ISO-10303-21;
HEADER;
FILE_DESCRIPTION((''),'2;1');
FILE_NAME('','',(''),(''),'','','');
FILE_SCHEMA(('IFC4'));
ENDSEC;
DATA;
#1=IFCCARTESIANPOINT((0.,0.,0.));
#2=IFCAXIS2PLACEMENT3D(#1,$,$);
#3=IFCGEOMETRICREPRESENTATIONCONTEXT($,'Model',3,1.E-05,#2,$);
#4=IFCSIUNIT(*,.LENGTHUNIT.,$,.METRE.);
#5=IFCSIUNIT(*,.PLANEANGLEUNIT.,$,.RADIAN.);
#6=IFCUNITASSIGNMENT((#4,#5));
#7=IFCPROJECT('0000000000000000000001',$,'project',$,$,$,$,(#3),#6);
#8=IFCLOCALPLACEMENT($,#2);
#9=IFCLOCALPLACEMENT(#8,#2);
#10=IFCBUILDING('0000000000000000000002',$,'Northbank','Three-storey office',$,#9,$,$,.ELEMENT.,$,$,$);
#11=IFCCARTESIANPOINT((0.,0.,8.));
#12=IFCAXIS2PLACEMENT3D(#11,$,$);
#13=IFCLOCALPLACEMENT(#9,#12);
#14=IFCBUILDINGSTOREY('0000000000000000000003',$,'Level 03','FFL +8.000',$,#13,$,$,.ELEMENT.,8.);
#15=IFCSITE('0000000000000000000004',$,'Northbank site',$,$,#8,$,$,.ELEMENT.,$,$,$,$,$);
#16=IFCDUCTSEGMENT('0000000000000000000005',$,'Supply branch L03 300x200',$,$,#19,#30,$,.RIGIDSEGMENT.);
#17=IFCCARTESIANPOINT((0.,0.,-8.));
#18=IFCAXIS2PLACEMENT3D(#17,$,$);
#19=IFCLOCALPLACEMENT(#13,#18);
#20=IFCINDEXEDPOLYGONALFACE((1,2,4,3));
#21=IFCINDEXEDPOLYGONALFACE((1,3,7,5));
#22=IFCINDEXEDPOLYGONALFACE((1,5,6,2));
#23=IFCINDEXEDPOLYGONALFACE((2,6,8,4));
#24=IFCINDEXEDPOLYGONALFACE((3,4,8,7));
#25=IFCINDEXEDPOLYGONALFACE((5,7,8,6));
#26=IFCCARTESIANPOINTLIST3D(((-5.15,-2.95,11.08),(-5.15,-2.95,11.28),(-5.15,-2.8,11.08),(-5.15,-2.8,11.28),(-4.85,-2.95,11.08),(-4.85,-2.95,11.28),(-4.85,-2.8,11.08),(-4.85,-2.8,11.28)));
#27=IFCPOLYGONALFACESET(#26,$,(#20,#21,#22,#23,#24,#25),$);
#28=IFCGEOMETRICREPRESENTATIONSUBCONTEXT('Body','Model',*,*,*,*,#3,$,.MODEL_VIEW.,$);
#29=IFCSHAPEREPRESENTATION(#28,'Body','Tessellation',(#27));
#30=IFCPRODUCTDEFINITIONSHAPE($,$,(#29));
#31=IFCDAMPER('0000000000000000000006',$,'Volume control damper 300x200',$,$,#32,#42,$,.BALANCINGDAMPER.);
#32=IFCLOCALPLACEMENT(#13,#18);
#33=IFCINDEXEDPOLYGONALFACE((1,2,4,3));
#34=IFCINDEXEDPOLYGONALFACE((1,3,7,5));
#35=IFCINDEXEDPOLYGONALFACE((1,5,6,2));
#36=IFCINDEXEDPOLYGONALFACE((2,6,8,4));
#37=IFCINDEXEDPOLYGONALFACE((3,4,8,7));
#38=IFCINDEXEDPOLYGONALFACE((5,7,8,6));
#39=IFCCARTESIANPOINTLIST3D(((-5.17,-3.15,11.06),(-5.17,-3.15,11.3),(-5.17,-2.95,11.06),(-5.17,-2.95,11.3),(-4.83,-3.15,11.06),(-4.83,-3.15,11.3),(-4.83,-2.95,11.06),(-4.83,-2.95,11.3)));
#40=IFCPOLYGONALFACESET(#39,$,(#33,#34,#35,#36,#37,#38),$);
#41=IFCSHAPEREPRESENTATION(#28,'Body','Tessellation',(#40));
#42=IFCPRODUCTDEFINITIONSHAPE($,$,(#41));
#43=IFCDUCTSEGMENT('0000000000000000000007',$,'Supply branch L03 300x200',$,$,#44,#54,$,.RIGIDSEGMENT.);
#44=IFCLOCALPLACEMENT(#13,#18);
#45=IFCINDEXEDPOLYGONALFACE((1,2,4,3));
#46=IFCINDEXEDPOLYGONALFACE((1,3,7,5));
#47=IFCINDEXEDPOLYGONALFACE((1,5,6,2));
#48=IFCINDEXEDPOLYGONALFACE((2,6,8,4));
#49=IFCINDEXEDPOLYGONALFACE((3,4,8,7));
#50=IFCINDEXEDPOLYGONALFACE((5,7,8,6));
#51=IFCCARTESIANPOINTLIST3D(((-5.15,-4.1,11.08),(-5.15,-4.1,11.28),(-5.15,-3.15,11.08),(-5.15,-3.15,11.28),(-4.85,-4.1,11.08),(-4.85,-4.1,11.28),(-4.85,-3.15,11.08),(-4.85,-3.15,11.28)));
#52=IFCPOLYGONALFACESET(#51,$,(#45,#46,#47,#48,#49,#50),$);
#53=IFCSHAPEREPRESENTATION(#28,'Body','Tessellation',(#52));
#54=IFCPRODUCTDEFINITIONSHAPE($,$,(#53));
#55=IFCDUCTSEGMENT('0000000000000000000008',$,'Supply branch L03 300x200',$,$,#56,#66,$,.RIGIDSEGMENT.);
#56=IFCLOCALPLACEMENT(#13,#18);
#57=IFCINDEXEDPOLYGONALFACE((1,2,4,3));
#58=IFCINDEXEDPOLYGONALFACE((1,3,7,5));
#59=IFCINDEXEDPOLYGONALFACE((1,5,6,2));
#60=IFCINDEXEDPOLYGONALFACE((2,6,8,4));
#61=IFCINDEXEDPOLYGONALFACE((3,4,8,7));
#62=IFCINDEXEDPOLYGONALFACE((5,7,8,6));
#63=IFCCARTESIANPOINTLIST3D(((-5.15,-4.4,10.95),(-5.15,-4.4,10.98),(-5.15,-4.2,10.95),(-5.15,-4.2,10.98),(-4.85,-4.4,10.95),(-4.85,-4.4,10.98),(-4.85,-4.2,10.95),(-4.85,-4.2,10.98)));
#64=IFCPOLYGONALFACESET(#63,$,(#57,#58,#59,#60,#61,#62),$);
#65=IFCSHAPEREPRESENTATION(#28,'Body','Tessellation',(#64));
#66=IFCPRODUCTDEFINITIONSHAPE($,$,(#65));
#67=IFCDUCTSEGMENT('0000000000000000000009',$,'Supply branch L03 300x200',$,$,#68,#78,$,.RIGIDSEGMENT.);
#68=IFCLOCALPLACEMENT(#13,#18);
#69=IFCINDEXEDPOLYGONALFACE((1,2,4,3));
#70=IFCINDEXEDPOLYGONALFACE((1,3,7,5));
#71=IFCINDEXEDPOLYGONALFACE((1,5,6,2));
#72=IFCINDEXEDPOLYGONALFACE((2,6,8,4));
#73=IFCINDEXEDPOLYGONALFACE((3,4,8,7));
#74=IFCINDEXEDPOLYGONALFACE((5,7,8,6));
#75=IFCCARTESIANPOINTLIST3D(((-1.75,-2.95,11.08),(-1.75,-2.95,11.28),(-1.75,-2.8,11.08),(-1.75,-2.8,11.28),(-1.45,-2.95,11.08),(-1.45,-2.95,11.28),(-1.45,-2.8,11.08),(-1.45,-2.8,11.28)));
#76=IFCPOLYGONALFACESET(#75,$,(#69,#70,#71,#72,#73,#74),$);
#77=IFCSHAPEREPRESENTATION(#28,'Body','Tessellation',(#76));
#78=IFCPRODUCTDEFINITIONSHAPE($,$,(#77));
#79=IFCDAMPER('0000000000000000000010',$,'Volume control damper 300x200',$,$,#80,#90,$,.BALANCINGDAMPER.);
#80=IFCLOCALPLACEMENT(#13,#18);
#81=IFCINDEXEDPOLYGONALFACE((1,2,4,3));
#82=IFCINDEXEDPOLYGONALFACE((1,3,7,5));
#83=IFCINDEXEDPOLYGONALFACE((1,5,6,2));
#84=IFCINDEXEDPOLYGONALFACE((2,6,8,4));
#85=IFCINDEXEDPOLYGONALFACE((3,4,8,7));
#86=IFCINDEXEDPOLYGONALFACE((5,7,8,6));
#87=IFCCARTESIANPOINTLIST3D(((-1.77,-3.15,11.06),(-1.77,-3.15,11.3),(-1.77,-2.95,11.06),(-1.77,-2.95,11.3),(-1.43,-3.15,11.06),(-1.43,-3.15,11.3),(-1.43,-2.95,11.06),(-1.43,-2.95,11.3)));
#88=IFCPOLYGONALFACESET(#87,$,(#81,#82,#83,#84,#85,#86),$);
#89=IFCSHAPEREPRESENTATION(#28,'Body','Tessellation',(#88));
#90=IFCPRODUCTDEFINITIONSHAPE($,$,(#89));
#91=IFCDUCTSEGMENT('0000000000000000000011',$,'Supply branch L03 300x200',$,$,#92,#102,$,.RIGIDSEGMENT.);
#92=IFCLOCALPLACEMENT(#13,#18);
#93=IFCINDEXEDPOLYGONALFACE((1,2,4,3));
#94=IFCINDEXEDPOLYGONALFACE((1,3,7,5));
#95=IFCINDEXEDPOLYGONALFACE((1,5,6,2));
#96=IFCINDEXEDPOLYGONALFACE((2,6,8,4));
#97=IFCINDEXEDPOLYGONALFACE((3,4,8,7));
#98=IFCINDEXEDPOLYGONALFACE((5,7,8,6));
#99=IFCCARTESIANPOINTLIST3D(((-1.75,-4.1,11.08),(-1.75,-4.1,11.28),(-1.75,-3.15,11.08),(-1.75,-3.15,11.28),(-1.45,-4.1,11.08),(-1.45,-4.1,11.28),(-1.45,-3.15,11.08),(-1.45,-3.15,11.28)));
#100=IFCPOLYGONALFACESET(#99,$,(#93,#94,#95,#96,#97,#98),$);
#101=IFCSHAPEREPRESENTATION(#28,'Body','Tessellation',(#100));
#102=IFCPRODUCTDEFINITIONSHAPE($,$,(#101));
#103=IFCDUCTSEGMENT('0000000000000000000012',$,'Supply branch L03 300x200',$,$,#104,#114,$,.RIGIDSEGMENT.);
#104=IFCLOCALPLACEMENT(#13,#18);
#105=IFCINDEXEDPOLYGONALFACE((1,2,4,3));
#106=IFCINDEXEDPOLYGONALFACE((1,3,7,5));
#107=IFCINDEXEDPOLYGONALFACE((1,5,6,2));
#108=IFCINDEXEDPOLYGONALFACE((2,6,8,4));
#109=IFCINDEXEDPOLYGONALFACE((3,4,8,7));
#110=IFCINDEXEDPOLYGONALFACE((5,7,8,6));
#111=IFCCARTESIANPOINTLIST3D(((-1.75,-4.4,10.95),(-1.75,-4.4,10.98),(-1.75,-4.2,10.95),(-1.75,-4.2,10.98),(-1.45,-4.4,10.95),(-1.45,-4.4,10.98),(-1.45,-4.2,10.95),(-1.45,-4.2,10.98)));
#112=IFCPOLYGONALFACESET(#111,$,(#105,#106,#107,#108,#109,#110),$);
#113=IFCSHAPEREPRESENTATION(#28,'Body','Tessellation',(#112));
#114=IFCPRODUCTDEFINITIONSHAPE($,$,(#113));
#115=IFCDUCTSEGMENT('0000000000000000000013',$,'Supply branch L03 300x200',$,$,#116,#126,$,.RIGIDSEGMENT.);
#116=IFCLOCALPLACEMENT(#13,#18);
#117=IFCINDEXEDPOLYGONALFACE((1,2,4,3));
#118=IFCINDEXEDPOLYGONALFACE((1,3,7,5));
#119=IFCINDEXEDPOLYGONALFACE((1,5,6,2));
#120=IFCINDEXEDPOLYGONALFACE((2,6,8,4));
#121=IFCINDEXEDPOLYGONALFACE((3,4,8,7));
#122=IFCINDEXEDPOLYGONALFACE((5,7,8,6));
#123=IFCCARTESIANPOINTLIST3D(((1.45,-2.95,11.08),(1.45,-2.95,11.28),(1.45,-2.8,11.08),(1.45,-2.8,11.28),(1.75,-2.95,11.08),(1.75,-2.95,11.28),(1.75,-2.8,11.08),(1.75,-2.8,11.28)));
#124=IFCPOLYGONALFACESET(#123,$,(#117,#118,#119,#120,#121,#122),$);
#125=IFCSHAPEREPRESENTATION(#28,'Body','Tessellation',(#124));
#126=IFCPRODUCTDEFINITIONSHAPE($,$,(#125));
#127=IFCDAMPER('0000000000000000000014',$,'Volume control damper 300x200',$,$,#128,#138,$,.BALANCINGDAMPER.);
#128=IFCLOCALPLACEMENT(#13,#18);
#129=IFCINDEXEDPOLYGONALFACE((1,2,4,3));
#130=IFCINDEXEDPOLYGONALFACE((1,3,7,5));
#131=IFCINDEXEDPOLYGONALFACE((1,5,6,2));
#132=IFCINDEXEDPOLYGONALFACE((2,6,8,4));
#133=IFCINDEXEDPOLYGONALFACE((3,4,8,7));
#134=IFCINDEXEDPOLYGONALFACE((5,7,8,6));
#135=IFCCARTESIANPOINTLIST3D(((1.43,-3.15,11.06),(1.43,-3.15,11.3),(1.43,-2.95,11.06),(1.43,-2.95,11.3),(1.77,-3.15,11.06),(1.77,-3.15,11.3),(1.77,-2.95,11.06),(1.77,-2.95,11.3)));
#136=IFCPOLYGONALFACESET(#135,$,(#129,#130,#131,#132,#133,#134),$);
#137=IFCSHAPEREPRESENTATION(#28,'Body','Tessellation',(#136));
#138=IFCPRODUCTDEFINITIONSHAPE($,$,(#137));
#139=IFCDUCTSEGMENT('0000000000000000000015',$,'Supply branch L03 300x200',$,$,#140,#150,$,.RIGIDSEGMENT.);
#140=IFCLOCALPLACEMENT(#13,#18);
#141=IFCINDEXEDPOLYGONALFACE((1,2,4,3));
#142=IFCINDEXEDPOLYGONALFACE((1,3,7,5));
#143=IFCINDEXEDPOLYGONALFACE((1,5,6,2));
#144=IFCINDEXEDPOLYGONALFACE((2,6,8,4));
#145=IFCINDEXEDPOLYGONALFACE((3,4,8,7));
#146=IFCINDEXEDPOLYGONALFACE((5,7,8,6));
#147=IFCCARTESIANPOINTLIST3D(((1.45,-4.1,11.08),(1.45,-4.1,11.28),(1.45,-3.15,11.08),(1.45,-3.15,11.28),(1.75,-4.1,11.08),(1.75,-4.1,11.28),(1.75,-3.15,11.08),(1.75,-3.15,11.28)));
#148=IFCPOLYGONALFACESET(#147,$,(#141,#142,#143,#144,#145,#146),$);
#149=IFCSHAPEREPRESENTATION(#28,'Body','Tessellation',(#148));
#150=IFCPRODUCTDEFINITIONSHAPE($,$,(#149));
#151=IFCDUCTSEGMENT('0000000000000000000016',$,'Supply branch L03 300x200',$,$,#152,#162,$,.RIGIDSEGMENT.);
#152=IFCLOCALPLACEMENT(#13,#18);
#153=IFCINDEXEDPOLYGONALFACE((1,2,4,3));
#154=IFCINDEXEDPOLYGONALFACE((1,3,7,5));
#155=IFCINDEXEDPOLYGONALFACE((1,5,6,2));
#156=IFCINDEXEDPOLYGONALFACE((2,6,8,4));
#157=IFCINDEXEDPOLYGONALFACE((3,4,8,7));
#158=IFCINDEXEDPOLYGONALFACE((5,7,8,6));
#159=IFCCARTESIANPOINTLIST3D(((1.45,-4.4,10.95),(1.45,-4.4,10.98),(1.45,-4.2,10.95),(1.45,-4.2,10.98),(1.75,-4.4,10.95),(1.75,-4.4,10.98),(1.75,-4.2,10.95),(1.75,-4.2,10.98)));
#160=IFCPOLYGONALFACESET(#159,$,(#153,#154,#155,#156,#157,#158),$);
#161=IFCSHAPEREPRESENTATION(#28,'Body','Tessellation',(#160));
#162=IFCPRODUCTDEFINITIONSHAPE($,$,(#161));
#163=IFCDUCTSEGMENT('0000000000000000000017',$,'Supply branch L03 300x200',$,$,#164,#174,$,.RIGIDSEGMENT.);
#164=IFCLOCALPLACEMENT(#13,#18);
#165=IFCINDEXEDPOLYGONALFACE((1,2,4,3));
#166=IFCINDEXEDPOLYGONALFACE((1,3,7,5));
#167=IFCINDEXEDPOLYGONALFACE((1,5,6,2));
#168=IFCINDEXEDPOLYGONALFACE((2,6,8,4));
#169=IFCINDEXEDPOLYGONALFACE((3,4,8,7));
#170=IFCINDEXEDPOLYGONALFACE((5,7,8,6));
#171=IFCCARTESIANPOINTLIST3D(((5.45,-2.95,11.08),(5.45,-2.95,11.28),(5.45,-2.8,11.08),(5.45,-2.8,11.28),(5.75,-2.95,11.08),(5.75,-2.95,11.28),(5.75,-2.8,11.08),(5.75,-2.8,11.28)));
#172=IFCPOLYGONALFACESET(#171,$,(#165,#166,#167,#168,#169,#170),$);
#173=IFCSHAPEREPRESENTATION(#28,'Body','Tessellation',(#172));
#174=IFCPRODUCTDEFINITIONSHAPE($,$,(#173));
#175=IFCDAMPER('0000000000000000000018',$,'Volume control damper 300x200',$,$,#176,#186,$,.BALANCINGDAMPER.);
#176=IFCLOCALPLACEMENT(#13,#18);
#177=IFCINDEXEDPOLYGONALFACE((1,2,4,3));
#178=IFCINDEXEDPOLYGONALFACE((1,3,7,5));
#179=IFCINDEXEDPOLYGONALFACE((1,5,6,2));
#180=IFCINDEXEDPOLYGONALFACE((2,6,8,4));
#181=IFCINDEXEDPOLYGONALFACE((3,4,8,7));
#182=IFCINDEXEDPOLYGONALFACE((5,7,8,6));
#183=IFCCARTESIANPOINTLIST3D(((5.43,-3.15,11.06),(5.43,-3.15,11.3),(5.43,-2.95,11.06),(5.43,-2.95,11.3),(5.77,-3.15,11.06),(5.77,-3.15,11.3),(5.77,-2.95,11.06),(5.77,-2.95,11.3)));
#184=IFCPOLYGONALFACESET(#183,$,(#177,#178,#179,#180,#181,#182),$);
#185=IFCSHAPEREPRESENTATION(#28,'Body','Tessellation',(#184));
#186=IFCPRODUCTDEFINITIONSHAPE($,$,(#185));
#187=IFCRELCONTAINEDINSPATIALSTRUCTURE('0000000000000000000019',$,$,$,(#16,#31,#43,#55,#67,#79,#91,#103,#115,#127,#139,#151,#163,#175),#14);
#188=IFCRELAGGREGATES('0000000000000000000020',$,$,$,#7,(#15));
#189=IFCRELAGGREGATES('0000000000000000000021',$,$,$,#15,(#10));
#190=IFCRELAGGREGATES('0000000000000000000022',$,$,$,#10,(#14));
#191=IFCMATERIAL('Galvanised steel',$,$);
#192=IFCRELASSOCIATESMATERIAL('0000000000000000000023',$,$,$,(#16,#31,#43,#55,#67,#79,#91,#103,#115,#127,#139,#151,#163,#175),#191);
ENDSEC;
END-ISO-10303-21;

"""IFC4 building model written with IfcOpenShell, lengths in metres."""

from ifc_helpers import new_model, si_unit, frame, origin, place, context, subcontext, project, spatial, rectangle, extrude, material, element, save


model = new_model("IFC4")

# Units and contexts
model_context = context("Model", 3, precision=1e-05, world=origin())
body_context = subcontext(model_context, "Body", "Model", "MODEL_VIEW")
ifc_project = project(units=[si_unit("LENGTHUNIT", "METRE"), si_unit("PLANEANGLEUNIT", "RADIAN")], contexts=[model_context])

# Site, building, storey
site_placement = place(None, origin())
site = spatial("IfcSite", under=ifc_project, at=site_placement, Name="Northbank site", CompositionType="ELEMENT")
building_placement = place(site_placement, origin())
building = spatial("IfcBuilding", under=site, at=building_placement, Name="Northbank", Description="Three-storey office", CompositionType="ELEMENT")
storey_placement = place(building_placement, frame((0.0, 0.0, 8.0)))
storey = spatial("IfcBuildingStorey", under=building, at=storey_placement, Name="Level 03", Description="FFL +8.000", CompositionType="ELEMENT", Elevation=8.0)

# Duct segment
ifc_material_1 = material(Name="Galvanised steel")
duct_segment_1_placement = place(storey_placement, frame((0.0, 0.0, -8.0)))
element("IfcDuctSegment", 1, at=duct_segment_1_placement, inside=storey, material=ifc_material_1, Name="Supply branch L03 300x200", PredefinedType="RIGIDSEGMENT", context=body_context, shape_type="SweptSolid", body=[
    extrude(rectangle(XDim=0.3, YDim=0.2), frame((-5.0, -2.8, 11.18), z_axis=(0.0, -1.0, 0.0), x_axis=(1.0, 0.0, 0.0)), (0.0, 0.0, 1.0), 0.15),
])

# Damper
damper_1_placement = place(storey_placement, frame((0.0, 0.0, -8.0)))
element("IfcDamper", 2, at=damper_1_placement, inside=storey, material=ifc_material_1, Name="Volume control damper 300x200", PredefinedType="BALANCINGDAMPER", context=body_context, shape_type="SweptSolid", body=[
    extrude(rectangle(XDim=0.34, YDim=0.24), frame((-5.0, -2.95, 11.18), z_axis=(0.0, -1.0, 0.0), x_axis=(1.0, 0.0, 0.0)), (0.0, 0.0, 1.0), 0.2),
])

# Duct segments
duct_segment_2_placement = place(storey_placement, frame((0.0, 0.0, -8.0)))
element("IfcDuctSegment", 3, at=duct_segment_2_placement, inside=storey, material=ifc_material_1, Name="Supply branch L03 300x200", PredefinedType="RIGIDSEGMENT", context=body_context, shape_type="SweptSolid", body=[
    extrude(rectangle(XDim=0.3, YDim=0.2), frame((-5.0, -3.15, 11.18), z_axis=(0.0, -1.0, 0.0), x_axis=(1.0, 0.0, 0.0)), (0.0, 0.0, 1.0), 0.95),
])
duct_segment_3_placement = place(storey_placement, frame((0.0, 0.0, -8.0)))
element("IfcDuctSegment", 4, at=duct_segment_3_placement, inside=storey, material=ifc_material_1, Name="Supply branch L03 300x200", PredefinedType="RIGIDSEGMENT", context=body_context, shape_type="SweptSolid", body=[
    extrude(rectangle(XDim=0.3, YDim=0.2), frame((-5.0, -4.3, 10.98), z_axis=(0.0, 0.0, -1.0), x_axis=(1.0, 0.0, 0.0)), (0.0, 0.0, 1.0), 0.03),
])

# Duct segment
duct_segment_4_placement = place(storey_placement, frame((0.0, 0.0, -8.0)))
element("IfcDuctSegment", 5, at=duct_segment_4_placement, inside=storey, material=ifc_material_1, Name="Supply branch L03 300x200", PredefinedType="RIGIDSEGMENT", context=body_context, shape_type="SweptSolid", body=[
    extrude(rectangle(XDim=0.3, YDim=0.2), frame((-1.6, -2.8, 11.18), z_axis=(0.0, -1.0, 0.0), x_axis=(1.0, 0.0, 0.0)), (0.0, 0.0, 1.0), 0.15),
])

# Damper
damper_2_placement = place(storey_placement, frame((0.0, 0.0, -8.0)))
element("IfcDamper", 6, at=damper_2_placement, inside=storey, material=ifc_material_1, Name="Volume control damper 300x200", PredefinedType="BALANCINGDAMPER", context=body_context, shape_type="SweptSolid", body=[
    extrude(rectangle(XDim=0.34, YDim=0.24), frame((-1.6, -2.95, 11.18), z_axis=(0.0, -1.0, 0.0), x_axis=(1.0, 0.0, 0.0)), (0.0, 0.0, 1.0), 0.2),
])

# Duct segments
duct_segment_5_placement = place(storey_placement, frame((0.0, 0.0, -8.0)))
element("IfcDuctSegment", 7, at=duct_segment_5_placement, inside=storey, material=ifc_material_1, Name="Supply branch L03 300x200", PredefinedType="RIGIDSEGMENT", context=body_context, shape_type="SweptSolid", body=[
    extrude(rectangle(XDim=0.3, YDim=0.2), frame((-1.6, -3.15, 11.18), z_axis=(0.0, -1.0, 0.0), x_axis=(1.0, 0.0, 0.0)), (0.0, 0.0, 1.0), 0.95),
])
duct_segment_6_placement = place(storey_placement, frame((0.0, 0.0, -8.0)))
element("IfcDuctSegment", 8, at=duct_segment_6_placement, inside=storey, material=ifc_material_1, Name="Supply branch L03 300x200", PredefinedType="RIGIDSEGMENT", context=body_context, shape_type="SweptSolid", body=[
    extrude(rectangle(XDim=0.3, YDim=0.2), frame((-1.6, -4.3, 10.98), z_axis=(0.0, 0.0, -1.0), x_axis=(1.0, 0.0, 0.0)), (0.0, 0.0, 1.0), 0.03),
])

# Duct segment
duct_segment_7_placement = place(storey_placement, frame((0.0, 0.0, -8.0)))
element("IfcDuctSegment", 9, at=duct_segment_7_placement, inside=storey, material=ifc_material_1, Name="Supply branch L03 300x200", PredefinedType="RIGIDSEGMENT", context=body_context, shape_type="SweptSolid", body=[
    extrude(rectangle(XDim=0.3, YDim=0.2), frame((1.6, -2.8, 11.18), z_axis=(0.0, -1.0, 0.0), x_axis=(1.0, 0.0, 0.0)), (0.0, 0.0, 1.0), 0.15),
])

# Damper
damper_3_placement = place(storey_placement, frame((0.0, 0.0, -8.0)))
element("IfcDamper", 10, at=damper_3_placement, inside=storey, material=ifc_material_1, Name="Volume control damper 300x200", PredefinedType="BALANCINGDAMPER", context=body_context, shape_type="SweptSolid", body=[
    extrude(rectangle(XDim=0.34, YDim=0.24), frame((1.6, -2.95, 11.18), z_axis=(0.0, -1.0, 0.0), x_axis=(1.0, 0.0, 0.0)), (0.0, 0.0, 1.0), 0.2),
])

# Duct segments
duct_segment_8_placement = place(storey_placement, frame((0.0, 0.0, -8.0)))
element("IfcDuctSegment", 11, at=duct_segment_8_placement, inside=storey, material=ifc_material_1, Name="Supply branch L03 300x200", PredefinedType="RIGIDSEGMENT", context=body_context, shape_type="SweptSolid", body=[
    extrude(rectangle(XDim=0.3, YDim=0.2), frame((1.6, -3.15, 11.18), z_axis=(0.0, -1.0, 0.0), x_axis=(1.0, 0.0, 0.0)), (0.0, 0.0, 1.0), 0.95),
])
duct_segment_9_placement = place(storey_placement, frame((0.0, 0.0, -8.0)))
element("IfcDuctSegment", 12, at=duct_segment_9_placement, inside=storey, material=ifc_material_1, Name="Supply branch L03 300x200", PredefinedType="RIGIDSEGMENT", context=body_context, shape_type="SweptSolid", body=[
    extrude(rectangle(XDim=0.3, YDim=0.2), frame((1.6, -4.3, 10.98), z_axis=(0.0, 0.0, -1.0), x_axis=(1.0, 0.0, 0.0)), (0.0, 0.0, 1.0), 0.03),
])

# Duct segment
duct_segment_10_placement = place(storey_placement, frame((0.0, 0.0, -8.0)))
element("IfcDuctSegment", 13, at=duct_segment_10_placement, inside=storey, material=ifc_material_1, Name="Supply branch L03 300x200", PredefinedType="RIGIDSEGMENT", context=body_context, shape_type="SweptSolid", body=[
    extrude(rectangle(XDim=0.3, YDim=0.2), frame((5.6, -2.8, 11.18), z_axis=(0.0, -1.0, 0.0), x_axis=(1.0, 0.0, 0.0)), (0.0, 0.0, 1.0), 0.15),
])

# Damper
damper_4_placement = place(storey_placement, frame((0.0, 0.0, -8.0)))
element("IfcDamper", 14, at=damper_4_placement, inside=storey, material=ifc_material_1, Name="Volume control damper 300x200", PredefinedType="BALANCINGDAMPER", context=body_context, shape_type="SweptSolid", body=[
    extrude(rectangle(XDim=0.34, YDim=0.24), frame((5.6, -2.95, 11.18), z_axis=(0.0, -1.0, 0.0), x_axis=(1.0, 0.0, 0.0)), (0.0, 0.0, 1.0), 0.2),
])

save(model, "model.ifc")
